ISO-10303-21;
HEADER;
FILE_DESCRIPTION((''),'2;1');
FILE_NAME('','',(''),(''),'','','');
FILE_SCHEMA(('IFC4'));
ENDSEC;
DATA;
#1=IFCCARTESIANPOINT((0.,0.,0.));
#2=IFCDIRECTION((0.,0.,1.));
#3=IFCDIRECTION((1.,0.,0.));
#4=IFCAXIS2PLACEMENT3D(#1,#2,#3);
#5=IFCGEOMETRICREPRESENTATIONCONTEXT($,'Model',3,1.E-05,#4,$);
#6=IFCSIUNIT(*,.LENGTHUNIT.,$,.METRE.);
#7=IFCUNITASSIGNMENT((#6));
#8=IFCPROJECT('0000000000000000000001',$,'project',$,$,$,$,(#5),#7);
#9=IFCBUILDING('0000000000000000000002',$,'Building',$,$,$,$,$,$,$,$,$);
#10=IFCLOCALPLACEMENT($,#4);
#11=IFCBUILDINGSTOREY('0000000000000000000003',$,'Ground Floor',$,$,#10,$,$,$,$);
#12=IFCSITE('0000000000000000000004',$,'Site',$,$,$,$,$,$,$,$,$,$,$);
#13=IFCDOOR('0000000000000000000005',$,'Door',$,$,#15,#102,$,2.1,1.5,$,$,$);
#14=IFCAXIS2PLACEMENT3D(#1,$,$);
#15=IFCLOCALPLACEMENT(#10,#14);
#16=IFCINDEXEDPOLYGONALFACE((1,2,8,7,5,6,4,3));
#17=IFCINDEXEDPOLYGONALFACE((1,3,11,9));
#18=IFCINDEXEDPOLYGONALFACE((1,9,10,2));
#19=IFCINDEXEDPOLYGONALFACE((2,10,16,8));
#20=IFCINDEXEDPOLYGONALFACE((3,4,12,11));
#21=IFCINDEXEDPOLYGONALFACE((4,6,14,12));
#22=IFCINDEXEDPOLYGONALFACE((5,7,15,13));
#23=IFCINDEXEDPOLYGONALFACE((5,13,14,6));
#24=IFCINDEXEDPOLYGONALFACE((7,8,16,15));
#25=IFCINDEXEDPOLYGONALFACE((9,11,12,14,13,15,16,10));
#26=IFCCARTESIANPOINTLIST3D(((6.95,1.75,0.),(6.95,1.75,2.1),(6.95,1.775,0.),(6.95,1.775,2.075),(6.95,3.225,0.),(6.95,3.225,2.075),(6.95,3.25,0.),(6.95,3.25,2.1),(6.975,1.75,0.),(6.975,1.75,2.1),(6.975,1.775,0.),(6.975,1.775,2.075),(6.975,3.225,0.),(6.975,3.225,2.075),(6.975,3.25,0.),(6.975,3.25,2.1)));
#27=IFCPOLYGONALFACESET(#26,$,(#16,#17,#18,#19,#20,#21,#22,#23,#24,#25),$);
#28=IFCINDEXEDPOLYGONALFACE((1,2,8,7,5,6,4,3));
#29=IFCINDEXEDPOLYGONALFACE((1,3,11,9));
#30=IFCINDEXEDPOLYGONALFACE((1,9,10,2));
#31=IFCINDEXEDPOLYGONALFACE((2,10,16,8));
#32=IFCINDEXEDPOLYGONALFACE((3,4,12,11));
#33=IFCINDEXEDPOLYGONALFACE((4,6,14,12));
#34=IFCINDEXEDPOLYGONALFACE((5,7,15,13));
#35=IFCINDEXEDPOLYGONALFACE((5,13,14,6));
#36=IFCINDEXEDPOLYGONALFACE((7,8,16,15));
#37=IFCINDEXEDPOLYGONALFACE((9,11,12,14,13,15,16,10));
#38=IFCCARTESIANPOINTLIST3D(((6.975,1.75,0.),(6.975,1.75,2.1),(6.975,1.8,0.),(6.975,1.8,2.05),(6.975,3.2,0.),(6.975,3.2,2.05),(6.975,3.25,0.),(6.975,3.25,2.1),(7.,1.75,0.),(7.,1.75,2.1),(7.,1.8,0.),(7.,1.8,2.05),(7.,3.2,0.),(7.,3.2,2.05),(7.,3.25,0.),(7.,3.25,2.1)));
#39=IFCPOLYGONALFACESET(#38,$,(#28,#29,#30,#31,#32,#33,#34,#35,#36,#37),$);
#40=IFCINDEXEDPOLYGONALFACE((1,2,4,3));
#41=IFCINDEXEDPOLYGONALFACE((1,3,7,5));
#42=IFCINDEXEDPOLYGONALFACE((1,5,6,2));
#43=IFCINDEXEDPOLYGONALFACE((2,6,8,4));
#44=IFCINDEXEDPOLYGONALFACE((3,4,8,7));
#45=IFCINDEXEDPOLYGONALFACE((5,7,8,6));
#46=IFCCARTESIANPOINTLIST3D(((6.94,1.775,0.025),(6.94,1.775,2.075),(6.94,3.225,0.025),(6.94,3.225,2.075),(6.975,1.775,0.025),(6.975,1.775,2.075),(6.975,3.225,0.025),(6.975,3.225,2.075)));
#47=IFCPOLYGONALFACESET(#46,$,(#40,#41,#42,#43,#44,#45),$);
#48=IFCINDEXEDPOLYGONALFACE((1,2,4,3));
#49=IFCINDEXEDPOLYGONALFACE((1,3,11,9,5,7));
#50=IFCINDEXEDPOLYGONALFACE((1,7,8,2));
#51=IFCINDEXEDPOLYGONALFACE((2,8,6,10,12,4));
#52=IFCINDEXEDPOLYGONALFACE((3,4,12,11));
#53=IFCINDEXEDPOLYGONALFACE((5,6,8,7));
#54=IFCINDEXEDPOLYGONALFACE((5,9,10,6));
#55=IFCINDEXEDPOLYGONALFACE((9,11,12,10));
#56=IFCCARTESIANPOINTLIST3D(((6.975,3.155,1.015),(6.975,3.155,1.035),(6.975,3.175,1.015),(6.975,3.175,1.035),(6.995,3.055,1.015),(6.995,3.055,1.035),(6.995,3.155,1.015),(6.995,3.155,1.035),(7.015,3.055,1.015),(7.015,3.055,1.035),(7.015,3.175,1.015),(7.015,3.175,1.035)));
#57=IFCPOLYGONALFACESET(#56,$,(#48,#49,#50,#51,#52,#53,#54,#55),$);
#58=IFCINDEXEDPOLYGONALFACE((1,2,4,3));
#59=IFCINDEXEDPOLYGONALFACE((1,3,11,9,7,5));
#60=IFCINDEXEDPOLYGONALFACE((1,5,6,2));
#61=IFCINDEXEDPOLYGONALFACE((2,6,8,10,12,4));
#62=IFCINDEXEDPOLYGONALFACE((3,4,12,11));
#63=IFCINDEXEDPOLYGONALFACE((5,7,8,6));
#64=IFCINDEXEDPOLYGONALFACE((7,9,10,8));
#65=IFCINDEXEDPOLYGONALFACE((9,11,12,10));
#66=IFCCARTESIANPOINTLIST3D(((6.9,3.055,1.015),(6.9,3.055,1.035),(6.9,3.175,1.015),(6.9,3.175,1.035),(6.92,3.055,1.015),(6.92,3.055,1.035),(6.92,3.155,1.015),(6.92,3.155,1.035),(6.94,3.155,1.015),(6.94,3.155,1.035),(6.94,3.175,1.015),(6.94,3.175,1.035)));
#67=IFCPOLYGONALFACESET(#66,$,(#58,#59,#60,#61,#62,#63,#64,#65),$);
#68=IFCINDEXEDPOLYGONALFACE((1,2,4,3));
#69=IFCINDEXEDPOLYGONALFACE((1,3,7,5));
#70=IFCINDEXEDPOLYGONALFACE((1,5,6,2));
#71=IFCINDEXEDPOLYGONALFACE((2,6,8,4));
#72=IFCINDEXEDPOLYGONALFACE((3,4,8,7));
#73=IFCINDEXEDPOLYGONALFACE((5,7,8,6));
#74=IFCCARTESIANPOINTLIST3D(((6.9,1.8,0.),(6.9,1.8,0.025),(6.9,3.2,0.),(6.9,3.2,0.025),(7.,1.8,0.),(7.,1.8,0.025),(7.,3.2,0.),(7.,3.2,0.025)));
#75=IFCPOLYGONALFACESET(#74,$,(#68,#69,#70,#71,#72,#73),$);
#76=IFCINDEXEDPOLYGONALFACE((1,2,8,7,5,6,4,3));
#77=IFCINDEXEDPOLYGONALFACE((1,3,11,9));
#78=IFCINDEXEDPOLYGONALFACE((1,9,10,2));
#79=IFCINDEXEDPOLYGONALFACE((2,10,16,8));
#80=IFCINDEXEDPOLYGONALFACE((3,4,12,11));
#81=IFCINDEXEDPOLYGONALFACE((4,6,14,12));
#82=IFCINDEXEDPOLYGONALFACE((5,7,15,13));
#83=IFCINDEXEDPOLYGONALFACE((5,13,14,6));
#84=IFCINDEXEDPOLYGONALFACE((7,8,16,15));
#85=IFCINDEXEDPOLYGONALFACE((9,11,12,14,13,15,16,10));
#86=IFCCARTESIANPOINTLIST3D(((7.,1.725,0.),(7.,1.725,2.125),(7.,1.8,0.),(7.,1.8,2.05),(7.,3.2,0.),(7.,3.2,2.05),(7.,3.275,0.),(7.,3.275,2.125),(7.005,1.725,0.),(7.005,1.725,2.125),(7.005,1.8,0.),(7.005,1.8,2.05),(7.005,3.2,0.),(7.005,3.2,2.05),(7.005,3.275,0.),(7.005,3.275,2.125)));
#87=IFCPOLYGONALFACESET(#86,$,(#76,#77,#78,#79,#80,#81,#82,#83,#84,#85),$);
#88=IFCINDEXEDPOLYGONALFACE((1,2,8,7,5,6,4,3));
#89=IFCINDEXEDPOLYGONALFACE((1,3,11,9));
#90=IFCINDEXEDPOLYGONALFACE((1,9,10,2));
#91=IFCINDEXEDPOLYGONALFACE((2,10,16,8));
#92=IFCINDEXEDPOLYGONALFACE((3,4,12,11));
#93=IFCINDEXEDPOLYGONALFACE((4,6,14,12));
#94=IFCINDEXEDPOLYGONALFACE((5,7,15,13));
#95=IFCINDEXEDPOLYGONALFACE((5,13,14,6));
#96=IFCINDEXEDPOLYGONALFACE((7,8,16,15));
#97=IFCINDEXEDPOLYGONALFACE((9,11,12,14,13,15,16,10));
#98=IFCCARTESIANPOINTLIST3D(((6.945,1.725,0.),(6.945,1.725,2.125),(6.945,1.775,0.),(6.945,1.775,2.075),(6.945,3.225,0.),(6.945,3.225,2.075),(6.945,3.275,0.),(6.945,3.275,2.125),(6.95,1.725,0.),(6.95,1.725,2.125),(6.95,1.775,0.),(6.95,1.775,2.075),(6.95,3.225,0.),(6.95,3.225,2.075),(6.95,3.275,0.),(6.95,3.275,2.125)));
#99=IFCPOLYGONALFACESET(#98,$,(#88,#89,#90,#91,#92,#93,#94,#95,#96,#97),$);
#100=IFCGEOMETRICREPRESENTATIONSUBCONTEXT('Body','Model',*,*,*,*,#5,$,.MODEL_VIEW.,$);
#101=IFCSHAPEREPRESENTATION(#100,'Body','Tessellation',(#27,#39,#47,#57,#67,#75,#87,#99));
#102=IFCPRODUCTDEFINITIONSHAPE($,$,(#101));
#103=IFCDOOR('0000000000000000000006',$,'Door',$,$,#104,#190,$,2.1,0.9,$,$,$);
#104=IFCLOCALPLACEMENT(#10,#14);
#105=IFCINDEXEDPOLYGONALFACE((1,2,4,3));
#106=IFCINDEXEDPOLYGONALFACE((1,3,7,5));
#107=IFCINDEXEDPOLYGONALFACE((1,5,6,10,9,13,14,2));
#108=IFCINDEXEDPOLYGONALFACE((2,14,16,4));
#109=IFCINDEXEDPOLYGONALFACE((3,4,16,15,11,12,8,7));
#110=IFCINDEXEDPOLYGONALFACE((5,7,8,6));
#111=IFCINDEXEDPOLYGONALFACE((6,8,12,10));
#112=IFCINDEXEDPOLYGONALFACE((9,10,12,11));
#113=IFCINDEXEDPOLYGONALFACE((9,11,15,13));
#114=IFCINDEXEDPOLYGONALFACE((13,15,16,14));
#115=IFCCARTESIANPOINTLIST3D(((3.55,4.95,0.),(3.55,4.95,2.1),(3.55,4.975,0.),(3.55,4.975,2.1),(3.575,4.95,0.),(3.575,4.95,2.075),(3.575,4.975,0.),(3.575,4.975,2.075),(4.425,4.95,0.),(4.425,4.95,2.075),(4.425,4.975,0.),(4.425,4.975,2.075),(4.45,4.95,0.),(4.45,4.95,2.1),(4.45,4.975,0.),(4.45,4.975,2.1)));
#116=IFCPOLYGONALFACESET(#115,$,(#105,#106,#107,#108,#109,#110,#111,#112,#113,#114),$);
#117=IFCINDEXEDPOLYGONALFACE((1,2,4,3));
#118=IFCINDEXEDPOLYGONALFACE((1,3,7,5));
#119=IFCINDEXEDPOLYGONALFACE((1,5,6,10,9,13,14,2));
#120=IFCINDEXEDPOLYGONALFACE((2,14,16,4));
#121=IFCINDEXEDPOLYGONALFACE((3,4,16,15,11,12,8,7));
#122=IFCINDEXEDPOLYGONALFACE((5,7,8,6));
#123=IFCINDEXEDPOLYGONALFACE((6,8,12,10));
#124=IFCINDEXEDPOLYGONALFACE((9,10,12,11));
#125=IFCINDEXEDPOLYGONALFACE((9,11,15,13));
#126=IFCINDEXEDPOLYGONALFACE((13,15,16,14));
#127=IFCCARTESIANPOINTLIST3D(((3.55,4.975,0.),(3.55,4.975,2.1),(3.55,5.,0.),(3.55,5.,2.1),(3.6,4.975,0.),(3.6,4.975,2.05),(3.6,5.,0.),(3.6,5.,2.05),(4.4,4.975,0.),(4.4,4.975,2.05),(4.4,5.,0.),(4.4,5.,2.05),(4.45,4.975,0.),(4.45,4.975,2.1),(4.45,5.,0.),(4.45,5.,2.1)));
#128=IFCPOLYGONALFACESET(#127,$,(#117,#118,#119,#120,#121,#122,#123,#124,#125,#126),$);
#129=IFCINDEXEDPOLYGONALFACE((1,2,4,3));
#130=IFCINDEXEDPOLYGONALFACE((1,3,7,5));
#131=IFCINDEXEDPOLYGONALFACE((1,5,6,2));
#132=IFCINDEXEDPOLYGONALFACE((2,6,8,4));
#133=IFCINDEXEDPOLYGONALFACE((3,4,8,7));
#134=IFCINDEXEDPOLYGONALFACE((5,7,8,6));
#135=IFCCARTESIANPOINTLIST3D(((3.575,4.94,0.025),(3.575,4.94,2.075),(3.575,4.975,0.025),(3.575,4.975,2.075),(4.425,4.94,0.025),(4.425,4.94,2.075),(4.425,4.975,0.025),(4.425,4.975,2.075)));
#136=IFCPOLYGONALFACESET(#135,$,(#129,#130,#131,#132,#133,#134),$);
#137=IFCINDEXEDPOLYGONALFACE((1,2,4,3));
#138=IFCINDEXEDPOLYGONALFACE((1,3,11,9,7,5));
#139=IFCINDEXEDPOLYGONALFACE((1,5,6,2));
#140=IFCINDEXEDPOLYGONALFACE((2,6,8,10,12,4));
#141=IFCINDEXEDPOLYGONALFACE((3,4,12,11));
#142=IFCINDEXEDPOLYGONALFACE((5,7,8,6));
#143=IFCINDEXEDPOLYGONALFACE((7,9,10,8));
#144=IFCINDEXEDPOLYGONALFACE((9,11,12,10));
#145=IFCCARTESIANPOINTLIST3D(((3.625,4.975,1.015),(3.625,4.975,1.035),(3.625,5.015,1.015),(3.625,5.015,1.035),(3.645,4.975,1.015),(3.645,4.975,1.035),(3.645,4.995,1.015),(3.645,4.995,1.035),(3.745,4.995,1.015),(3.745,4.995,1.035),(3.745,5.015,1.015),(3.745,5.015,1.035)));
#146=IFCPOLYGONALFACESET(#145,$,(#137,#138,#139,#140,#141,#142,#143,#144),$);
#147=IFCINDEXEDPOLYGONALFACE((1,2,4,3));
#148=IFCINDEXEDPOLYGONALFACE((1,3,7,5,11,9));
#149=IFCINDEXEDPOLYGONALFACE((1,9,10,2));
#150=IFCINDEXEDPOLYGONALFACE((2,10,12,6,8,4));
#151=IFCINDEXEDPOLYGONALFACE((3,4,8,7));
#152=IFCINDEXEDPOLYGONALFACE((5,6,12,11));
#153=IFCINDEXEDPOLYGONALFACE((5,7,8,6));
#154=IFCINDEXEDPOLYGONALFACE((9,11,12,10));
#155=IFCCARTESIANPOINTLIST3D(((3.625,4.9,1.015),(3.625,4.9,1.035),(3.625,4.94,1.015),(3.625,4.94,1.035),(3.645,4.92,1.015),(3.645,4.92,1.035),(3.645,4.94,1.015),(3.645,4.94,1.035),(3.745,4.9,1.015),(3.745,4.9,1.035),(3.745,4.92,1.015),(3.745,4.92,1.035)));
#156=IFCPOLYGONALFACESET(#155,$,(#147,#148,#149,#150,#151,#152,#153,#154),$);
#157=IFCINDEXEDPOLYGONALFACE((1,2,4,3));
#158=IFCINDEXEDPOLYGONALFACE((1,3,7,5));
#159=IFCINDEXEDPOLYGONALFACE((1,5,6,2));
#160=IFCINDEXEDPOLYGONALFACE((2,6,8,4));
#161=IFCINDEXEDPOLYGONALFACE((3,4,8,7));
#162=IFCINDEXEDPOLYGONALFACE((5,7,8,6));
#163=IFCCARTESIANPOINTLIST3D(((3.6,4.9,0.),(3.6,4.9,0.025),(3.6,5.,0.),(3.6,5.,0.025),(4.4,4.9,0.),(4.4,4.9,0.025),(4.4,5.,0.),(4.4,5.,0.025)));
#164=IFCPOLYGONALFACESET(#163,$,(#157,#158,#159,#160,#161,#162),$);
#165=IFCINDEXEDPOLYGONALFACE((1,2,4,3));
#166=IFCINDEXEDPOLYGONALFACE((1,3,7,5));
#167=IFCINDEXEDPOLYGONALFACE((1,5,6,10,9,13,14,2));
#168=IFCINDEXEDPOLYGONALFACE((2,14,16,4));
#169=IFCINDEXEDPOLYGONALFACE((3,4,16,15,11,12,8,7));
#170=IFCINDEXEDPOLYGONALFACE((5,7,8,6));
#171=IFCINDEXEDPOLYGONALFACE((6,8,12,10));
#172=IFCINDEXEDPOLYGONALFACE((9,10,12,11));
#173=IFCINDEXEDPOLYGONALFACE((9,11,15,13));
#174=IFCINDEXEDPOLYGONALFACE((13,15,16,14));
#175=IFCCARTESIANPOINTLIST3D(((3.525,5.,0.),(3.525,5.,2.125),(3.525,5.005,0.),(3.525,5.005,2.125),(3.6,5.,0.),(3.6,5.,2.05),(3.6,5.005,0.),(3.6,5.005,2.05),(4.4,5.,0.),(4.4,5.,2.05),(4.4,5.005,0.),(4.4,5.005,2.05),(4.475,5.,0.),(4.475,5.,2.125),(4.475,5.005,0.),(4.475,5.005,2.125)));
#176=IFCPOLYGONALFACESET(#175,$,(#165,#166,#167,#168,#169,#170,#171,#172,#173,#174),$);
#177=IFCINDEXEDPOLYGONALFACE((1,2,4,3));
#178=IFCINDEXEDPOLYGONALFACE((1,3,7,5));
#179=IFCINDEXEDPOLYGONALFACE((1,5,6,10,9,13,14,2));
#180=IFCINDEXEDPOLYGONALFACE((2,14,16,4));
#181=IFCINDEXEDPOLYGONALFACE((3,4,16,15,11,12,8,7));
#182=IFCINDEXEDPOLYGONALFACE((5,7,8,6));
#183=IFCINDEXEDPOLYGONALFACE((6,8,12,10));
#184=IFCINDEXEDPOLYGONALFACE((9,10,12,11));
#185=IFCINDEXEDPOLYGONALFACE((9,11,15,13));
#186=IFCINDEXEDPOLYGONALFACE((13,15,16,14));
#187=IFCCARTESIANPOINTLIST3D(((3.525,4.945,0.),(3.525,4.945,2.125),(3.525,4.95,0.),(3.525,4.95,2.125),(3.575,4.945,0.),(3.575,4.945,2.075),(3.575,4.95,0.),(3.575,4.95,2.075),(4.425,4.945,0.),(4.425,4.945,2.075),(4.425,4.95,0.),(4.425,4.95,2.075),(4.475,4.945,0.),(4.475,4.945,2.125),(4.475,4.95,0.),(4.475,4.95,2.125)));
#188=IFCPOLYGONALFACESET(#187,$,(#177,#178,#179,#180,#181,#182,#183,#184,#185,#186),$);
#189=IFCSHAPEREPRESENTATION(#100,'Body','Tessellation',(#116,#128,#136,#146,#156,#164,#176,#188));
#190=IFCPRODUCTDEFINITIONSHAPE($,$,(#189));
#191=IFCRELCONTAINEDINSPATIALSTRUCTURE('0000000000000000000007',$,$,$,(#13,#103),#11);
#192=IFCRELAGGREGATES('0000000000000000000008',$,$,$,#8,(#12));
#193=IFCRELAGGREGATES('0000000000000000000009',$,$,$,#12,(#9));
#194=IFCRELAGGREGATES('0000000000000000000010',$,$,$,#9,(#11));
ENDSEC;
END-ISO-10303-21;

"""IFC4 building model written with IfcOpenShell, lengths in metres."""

from ifc_helpers import new_model, si_unit, frame, origin_with_axes, place, context, subcontext, project, spatial, line, indexed_curve, outline, extrude, element, save


model = new_model("IFC4")

# Units and contexts
model_context = context("Model", 3, precision=1e-05, world=origin_with_axes())
body_context = subcontext(model_context, "Body", "Model", "MODEL_VIEW")
ifc_project = project(units=[si_unit("LENGTHUNIT", "METRE")], contexts=[model_context])

# Site, building, storey
site = spatial("IfcSite", under=ifc_project, Name="Site")
building = spatial("IfcBuilding", under=site, Name="Building")
storey_placement = place(None, origin_with_axes())
storey = spatial("IfcBuildingStorey", under=building, at=storey_placement, Name="Ground Floor")

# Doors
door_1_placement = place(storey_placement, frame((7.0, 1.75, 0.0), z_axis=(0.0, 0.0, 1.0), x_axis=(0.0, 1.0, 0.0)))
element("IfcDoor", 1, at=door_1_placement, inside=storey, Name="Door", OverallHeight=2.1, OverallWidth=1.5, context=body_context, shape_type="SweptSolid", body=[
    extrude(outline(indexed_curve([(0.0, 0.0), (0.0, 2.1), (1.5, 2.1), (1.5, 0.0), (1.475, 0.0), (1.475, 2.075), (0.025, 2.075), (0.025, 0.0)], segments=[line(1, 2, 3, 4, 5, 6, 7, 8, 1)])), frame((0.0, 0.025, 0.0), z_axis=(0.0, -1.0, 0.0), x_axis=(1.0, 0.0, 0.0)), (0.0, 0.0, -1.0), 0.025),
    extrude(outline(indexed_curve([(0.0, 0.0), (0.0, 2.1), (1.5, 2.1), (1.5, 0.0), (1.45, 0.0), (1.45, 2.05), (0.05, 2.05), (0.05, 0.0)], segments=[line(1, 2, 3, 4, 5, 6, 7, 8, 1)])), frame((0.0, 0.0, 0.0), z_axis=(0.0, -1.0, 0.0), x_axis=(1.0, 0.0, 0.0)), (0.0, 0.0, -1.0), 0.025),
    extrude(outline(indexed_curve([(0.0, 0.0), (1.45, 0.0), (1.45, 0.035), (0.0, 0.035)], segments=[line(1, 2, 3, 4, 1)])), frame((0.025, 0.025, 0.025), z_axis=(0.0, 0.0, 1.0), x_axis=(1.0, 0.0, 0.0)), (0.0, 0.0, 1.0), 2.05),
    extrude(outline(indexed_curve([(0.0, 0.0), (0.0, -0.04), (-0.12, -0.04), (-0.12, -0.02), (-0.02, -0.02), (-0.02, 0.0)], segments=[line(1, 2, 3, 4, 5, 6, 1)])), frame((1.425, 0.025, 1.015), z_axis=(0.0, 0.0, 1.0), x_axis=(1.0, 0.0, 0.0)), (0.0, 0.0, 1.0), 0.02),
    extrude(outline(indexed_curve([(0.0, 0.0), (0.0, 0.04), (-0.12, 0.04), (-0.12, 0.02), (-0.02, 0.02), (-0.02, 0.0)], segments=[line(1, 2, 3, 4, 5, 6, 1)])), frame((1.425, 0.06, 1.015), z_axis=(0.0, 0.0, 1.0), x_axis=(1.0, 0.0, 0.0)), (0.0, 0.0, 1.0), 0.02),
    extrude(outline(indexed_curve([(0.0, 0.0), (1.4, 0.0), (1.4, 0.1), (0.0, 0.1)], segments=[line(1, 2, 3, 4, 1)])), frame((0.05, 0.0, 0.0), z_axis=(0.0, 0.0, 1.0), x_axis=(1.0, 0.0, 0.0)), (0.0, 0.0, 1.0), 0.025),
    extrude(outline(indexed_curve([(0.0, 0.0), (0.0, 2.125), (1.55, 2.125), (1.55, 0.0), (1.475, 0.0), (1.475, 2.05), (0.075, 2.05), (0.075, 0.0)], segments=[line(1, 2, 3, 4, 5, 6, 7, 8, 1)])), frame((-0.025, -0.005, 0.0), z_axis=(0.0, -1.0, 0.0), x_axis=(1.0, 0.0, 0.0)), (0.0, 0.0, -1.0), 0.005),
    extrude(outline(indexed_curve([(0.0, 0.0), (0.0, 2.125), (1.55, 2.125), (1.55, 0.0), (1.5, 0.0), (1.5, 2.075), (0.05, 2.075), (0.05, 0.0)], segments=[line(1, 2, 3, 4, 5, 6, 7, 8, 1)])), frame((-0.025, 0.05, 0.0), z_axis=(0.0, -1.0, 0.0), x_axis=(1.0, 0.0, 0.0)), (0.0, 0.0, -1.0), 0.005),
])
door_2_placement = place(storey_placement, frame((4.45, 5.0, 0.0), z_axis=(0.0, 0.0, 1.0), x_axis=(-1.0, 0.0, 0.0)))
element("IfcDoor", 2, at=door_2_placement, inside=storey, Name="Door", OverallHeight=2.1, OverallWidth=0.9, context=body_context, shape_type="SweptSolid", body=[
    extrude(outline(indexed_curve([(0.0, 0.0), (0.0, 2.1), (0.9, 2.1), (0.9, 0.0), (0.875, 0.0), (0.875, 2.075), (0.025, 2.075), (0.025, 0.0)], segments=[line(1, 2, 3, 4, 5, 6, 7, 8, 1)])), frame((0.0, 0.025, 0.0), z_axis=(0.0, -1.0, 0.0), x_axis=(1.0, 0.0, 0.0)), (0.0, 0.0, -1.0), 0.025),
    extrude(outline(indexed_curve([(0.0, 0.0), (0.0, 2.1), (0.9, 2.1), (0.9, 0.0), (0.85, 0.0), (0.85, 2.05), (0.05, 2.05), (0.05, 0.0)], segments=[line(1, 2, 3, 4, 5, 6, 7, 8, 1)])), frame((0.0, 0.0, 0.0), z_axis=(0.0, -1.0, 0.0), x_axis=(1.0, 0.0, 0.0)), (0.0, 0.0, -1.0), 0.025),
    extrude(outline(indexed_curve([(0.0, 0.0), (0.85, 0.0), (0.85, 0.035), (0.0, 0.035)], segments=[line(1, 2, 3, 4, 1)])), frame((0.025, 0.025, 0.025), z_axis=(0.0, 0.0, 1.0), x_axis=(1.0, 0.0, 0.0)), (0.0, 0.0, 1.0), 2.05),
    extrude(outline(indexed_curve([(0.0, 0.0), (0.0, -0.04), (-0.12, -0.04), (-0.12, -0.02), (-0.02, -0.02), (-0.02, 0.0)], segments=[line(1, 2, 3, 4, 5, 6, 1)])), frame((0.825, 0.025, 1.015), z_axis=(0.0, 0.0, 1.0), x_axis=(1.0, 0.0, 0.0)), (0.0, 0.0, 1.0), 0.02),
    extrude(outline(indexed_curve([(0.0, 0.0), (0.0, 0.04), (-0.12, 0.04), (-0.12, 0.02), (-0.02, 0.02), (-0.02, 0.0)], segments=[line(1, 2, 3, 4, 5, 6, 1)])), frame((0.825, 0.06, 1.015), z_axis=(0.0, 0.0, 1.0), x_axis=(1.0, 0.0, 0.0)), (0.0, 0.0, 1.0), 0.02),
    extrude(outline(indexed_curve([(0.0, 0.0), (0.8, 0.0), (0.8, 0.1), (0.0, 0.1)], segments=[line(1, 2, 3, 4, 1)])), frame((0.05, 0.0, 0.0), z_axis=(0.0, 0.0, 1.0), x_axis=(1.0, 0.0, 0.0)), (0.0, 0.0, 1.0), 0.025),
    extrude(outline(indexed_curve([(0.0, 0.0), (0.0, 2.125), (0.95, 2.125), (0.95, 0.0), (0.875, 0.0), (0.875, 2.05), (0.075, 2.05), (0.075, 0.0)], segments=[line(1, 2, 3, 4, 5, 6, 7, 8, 1)])), frame((-0.025, -0.005, 0.0), z_axis=(0.0, -1.0, 0.0), x_axis=(1.0, 0.0, 0.0)), (0.0, 0.0, -1.0), 0.005),
    extrude(outline(indexed_curve([(0.0, 0.0), (0.0, 2.125), (0.95, 2.125), (0.95, 0.0), (0.9, 0.0), (0.9, 2.075), (0.05, 2.075), (0.05, 0.0)], segments=[line(1, 2, 3, 4, 5, 6, 7, 8, 1)])), frame((-0.025, 0.05, 0.0), z_axis=(0.0, -1.0, 0.0), x_axis=(1.0, 0.0, 0.0)), (0.0, 0.0, -1.0), 0.005),
])

save(model, "model.ifc")
